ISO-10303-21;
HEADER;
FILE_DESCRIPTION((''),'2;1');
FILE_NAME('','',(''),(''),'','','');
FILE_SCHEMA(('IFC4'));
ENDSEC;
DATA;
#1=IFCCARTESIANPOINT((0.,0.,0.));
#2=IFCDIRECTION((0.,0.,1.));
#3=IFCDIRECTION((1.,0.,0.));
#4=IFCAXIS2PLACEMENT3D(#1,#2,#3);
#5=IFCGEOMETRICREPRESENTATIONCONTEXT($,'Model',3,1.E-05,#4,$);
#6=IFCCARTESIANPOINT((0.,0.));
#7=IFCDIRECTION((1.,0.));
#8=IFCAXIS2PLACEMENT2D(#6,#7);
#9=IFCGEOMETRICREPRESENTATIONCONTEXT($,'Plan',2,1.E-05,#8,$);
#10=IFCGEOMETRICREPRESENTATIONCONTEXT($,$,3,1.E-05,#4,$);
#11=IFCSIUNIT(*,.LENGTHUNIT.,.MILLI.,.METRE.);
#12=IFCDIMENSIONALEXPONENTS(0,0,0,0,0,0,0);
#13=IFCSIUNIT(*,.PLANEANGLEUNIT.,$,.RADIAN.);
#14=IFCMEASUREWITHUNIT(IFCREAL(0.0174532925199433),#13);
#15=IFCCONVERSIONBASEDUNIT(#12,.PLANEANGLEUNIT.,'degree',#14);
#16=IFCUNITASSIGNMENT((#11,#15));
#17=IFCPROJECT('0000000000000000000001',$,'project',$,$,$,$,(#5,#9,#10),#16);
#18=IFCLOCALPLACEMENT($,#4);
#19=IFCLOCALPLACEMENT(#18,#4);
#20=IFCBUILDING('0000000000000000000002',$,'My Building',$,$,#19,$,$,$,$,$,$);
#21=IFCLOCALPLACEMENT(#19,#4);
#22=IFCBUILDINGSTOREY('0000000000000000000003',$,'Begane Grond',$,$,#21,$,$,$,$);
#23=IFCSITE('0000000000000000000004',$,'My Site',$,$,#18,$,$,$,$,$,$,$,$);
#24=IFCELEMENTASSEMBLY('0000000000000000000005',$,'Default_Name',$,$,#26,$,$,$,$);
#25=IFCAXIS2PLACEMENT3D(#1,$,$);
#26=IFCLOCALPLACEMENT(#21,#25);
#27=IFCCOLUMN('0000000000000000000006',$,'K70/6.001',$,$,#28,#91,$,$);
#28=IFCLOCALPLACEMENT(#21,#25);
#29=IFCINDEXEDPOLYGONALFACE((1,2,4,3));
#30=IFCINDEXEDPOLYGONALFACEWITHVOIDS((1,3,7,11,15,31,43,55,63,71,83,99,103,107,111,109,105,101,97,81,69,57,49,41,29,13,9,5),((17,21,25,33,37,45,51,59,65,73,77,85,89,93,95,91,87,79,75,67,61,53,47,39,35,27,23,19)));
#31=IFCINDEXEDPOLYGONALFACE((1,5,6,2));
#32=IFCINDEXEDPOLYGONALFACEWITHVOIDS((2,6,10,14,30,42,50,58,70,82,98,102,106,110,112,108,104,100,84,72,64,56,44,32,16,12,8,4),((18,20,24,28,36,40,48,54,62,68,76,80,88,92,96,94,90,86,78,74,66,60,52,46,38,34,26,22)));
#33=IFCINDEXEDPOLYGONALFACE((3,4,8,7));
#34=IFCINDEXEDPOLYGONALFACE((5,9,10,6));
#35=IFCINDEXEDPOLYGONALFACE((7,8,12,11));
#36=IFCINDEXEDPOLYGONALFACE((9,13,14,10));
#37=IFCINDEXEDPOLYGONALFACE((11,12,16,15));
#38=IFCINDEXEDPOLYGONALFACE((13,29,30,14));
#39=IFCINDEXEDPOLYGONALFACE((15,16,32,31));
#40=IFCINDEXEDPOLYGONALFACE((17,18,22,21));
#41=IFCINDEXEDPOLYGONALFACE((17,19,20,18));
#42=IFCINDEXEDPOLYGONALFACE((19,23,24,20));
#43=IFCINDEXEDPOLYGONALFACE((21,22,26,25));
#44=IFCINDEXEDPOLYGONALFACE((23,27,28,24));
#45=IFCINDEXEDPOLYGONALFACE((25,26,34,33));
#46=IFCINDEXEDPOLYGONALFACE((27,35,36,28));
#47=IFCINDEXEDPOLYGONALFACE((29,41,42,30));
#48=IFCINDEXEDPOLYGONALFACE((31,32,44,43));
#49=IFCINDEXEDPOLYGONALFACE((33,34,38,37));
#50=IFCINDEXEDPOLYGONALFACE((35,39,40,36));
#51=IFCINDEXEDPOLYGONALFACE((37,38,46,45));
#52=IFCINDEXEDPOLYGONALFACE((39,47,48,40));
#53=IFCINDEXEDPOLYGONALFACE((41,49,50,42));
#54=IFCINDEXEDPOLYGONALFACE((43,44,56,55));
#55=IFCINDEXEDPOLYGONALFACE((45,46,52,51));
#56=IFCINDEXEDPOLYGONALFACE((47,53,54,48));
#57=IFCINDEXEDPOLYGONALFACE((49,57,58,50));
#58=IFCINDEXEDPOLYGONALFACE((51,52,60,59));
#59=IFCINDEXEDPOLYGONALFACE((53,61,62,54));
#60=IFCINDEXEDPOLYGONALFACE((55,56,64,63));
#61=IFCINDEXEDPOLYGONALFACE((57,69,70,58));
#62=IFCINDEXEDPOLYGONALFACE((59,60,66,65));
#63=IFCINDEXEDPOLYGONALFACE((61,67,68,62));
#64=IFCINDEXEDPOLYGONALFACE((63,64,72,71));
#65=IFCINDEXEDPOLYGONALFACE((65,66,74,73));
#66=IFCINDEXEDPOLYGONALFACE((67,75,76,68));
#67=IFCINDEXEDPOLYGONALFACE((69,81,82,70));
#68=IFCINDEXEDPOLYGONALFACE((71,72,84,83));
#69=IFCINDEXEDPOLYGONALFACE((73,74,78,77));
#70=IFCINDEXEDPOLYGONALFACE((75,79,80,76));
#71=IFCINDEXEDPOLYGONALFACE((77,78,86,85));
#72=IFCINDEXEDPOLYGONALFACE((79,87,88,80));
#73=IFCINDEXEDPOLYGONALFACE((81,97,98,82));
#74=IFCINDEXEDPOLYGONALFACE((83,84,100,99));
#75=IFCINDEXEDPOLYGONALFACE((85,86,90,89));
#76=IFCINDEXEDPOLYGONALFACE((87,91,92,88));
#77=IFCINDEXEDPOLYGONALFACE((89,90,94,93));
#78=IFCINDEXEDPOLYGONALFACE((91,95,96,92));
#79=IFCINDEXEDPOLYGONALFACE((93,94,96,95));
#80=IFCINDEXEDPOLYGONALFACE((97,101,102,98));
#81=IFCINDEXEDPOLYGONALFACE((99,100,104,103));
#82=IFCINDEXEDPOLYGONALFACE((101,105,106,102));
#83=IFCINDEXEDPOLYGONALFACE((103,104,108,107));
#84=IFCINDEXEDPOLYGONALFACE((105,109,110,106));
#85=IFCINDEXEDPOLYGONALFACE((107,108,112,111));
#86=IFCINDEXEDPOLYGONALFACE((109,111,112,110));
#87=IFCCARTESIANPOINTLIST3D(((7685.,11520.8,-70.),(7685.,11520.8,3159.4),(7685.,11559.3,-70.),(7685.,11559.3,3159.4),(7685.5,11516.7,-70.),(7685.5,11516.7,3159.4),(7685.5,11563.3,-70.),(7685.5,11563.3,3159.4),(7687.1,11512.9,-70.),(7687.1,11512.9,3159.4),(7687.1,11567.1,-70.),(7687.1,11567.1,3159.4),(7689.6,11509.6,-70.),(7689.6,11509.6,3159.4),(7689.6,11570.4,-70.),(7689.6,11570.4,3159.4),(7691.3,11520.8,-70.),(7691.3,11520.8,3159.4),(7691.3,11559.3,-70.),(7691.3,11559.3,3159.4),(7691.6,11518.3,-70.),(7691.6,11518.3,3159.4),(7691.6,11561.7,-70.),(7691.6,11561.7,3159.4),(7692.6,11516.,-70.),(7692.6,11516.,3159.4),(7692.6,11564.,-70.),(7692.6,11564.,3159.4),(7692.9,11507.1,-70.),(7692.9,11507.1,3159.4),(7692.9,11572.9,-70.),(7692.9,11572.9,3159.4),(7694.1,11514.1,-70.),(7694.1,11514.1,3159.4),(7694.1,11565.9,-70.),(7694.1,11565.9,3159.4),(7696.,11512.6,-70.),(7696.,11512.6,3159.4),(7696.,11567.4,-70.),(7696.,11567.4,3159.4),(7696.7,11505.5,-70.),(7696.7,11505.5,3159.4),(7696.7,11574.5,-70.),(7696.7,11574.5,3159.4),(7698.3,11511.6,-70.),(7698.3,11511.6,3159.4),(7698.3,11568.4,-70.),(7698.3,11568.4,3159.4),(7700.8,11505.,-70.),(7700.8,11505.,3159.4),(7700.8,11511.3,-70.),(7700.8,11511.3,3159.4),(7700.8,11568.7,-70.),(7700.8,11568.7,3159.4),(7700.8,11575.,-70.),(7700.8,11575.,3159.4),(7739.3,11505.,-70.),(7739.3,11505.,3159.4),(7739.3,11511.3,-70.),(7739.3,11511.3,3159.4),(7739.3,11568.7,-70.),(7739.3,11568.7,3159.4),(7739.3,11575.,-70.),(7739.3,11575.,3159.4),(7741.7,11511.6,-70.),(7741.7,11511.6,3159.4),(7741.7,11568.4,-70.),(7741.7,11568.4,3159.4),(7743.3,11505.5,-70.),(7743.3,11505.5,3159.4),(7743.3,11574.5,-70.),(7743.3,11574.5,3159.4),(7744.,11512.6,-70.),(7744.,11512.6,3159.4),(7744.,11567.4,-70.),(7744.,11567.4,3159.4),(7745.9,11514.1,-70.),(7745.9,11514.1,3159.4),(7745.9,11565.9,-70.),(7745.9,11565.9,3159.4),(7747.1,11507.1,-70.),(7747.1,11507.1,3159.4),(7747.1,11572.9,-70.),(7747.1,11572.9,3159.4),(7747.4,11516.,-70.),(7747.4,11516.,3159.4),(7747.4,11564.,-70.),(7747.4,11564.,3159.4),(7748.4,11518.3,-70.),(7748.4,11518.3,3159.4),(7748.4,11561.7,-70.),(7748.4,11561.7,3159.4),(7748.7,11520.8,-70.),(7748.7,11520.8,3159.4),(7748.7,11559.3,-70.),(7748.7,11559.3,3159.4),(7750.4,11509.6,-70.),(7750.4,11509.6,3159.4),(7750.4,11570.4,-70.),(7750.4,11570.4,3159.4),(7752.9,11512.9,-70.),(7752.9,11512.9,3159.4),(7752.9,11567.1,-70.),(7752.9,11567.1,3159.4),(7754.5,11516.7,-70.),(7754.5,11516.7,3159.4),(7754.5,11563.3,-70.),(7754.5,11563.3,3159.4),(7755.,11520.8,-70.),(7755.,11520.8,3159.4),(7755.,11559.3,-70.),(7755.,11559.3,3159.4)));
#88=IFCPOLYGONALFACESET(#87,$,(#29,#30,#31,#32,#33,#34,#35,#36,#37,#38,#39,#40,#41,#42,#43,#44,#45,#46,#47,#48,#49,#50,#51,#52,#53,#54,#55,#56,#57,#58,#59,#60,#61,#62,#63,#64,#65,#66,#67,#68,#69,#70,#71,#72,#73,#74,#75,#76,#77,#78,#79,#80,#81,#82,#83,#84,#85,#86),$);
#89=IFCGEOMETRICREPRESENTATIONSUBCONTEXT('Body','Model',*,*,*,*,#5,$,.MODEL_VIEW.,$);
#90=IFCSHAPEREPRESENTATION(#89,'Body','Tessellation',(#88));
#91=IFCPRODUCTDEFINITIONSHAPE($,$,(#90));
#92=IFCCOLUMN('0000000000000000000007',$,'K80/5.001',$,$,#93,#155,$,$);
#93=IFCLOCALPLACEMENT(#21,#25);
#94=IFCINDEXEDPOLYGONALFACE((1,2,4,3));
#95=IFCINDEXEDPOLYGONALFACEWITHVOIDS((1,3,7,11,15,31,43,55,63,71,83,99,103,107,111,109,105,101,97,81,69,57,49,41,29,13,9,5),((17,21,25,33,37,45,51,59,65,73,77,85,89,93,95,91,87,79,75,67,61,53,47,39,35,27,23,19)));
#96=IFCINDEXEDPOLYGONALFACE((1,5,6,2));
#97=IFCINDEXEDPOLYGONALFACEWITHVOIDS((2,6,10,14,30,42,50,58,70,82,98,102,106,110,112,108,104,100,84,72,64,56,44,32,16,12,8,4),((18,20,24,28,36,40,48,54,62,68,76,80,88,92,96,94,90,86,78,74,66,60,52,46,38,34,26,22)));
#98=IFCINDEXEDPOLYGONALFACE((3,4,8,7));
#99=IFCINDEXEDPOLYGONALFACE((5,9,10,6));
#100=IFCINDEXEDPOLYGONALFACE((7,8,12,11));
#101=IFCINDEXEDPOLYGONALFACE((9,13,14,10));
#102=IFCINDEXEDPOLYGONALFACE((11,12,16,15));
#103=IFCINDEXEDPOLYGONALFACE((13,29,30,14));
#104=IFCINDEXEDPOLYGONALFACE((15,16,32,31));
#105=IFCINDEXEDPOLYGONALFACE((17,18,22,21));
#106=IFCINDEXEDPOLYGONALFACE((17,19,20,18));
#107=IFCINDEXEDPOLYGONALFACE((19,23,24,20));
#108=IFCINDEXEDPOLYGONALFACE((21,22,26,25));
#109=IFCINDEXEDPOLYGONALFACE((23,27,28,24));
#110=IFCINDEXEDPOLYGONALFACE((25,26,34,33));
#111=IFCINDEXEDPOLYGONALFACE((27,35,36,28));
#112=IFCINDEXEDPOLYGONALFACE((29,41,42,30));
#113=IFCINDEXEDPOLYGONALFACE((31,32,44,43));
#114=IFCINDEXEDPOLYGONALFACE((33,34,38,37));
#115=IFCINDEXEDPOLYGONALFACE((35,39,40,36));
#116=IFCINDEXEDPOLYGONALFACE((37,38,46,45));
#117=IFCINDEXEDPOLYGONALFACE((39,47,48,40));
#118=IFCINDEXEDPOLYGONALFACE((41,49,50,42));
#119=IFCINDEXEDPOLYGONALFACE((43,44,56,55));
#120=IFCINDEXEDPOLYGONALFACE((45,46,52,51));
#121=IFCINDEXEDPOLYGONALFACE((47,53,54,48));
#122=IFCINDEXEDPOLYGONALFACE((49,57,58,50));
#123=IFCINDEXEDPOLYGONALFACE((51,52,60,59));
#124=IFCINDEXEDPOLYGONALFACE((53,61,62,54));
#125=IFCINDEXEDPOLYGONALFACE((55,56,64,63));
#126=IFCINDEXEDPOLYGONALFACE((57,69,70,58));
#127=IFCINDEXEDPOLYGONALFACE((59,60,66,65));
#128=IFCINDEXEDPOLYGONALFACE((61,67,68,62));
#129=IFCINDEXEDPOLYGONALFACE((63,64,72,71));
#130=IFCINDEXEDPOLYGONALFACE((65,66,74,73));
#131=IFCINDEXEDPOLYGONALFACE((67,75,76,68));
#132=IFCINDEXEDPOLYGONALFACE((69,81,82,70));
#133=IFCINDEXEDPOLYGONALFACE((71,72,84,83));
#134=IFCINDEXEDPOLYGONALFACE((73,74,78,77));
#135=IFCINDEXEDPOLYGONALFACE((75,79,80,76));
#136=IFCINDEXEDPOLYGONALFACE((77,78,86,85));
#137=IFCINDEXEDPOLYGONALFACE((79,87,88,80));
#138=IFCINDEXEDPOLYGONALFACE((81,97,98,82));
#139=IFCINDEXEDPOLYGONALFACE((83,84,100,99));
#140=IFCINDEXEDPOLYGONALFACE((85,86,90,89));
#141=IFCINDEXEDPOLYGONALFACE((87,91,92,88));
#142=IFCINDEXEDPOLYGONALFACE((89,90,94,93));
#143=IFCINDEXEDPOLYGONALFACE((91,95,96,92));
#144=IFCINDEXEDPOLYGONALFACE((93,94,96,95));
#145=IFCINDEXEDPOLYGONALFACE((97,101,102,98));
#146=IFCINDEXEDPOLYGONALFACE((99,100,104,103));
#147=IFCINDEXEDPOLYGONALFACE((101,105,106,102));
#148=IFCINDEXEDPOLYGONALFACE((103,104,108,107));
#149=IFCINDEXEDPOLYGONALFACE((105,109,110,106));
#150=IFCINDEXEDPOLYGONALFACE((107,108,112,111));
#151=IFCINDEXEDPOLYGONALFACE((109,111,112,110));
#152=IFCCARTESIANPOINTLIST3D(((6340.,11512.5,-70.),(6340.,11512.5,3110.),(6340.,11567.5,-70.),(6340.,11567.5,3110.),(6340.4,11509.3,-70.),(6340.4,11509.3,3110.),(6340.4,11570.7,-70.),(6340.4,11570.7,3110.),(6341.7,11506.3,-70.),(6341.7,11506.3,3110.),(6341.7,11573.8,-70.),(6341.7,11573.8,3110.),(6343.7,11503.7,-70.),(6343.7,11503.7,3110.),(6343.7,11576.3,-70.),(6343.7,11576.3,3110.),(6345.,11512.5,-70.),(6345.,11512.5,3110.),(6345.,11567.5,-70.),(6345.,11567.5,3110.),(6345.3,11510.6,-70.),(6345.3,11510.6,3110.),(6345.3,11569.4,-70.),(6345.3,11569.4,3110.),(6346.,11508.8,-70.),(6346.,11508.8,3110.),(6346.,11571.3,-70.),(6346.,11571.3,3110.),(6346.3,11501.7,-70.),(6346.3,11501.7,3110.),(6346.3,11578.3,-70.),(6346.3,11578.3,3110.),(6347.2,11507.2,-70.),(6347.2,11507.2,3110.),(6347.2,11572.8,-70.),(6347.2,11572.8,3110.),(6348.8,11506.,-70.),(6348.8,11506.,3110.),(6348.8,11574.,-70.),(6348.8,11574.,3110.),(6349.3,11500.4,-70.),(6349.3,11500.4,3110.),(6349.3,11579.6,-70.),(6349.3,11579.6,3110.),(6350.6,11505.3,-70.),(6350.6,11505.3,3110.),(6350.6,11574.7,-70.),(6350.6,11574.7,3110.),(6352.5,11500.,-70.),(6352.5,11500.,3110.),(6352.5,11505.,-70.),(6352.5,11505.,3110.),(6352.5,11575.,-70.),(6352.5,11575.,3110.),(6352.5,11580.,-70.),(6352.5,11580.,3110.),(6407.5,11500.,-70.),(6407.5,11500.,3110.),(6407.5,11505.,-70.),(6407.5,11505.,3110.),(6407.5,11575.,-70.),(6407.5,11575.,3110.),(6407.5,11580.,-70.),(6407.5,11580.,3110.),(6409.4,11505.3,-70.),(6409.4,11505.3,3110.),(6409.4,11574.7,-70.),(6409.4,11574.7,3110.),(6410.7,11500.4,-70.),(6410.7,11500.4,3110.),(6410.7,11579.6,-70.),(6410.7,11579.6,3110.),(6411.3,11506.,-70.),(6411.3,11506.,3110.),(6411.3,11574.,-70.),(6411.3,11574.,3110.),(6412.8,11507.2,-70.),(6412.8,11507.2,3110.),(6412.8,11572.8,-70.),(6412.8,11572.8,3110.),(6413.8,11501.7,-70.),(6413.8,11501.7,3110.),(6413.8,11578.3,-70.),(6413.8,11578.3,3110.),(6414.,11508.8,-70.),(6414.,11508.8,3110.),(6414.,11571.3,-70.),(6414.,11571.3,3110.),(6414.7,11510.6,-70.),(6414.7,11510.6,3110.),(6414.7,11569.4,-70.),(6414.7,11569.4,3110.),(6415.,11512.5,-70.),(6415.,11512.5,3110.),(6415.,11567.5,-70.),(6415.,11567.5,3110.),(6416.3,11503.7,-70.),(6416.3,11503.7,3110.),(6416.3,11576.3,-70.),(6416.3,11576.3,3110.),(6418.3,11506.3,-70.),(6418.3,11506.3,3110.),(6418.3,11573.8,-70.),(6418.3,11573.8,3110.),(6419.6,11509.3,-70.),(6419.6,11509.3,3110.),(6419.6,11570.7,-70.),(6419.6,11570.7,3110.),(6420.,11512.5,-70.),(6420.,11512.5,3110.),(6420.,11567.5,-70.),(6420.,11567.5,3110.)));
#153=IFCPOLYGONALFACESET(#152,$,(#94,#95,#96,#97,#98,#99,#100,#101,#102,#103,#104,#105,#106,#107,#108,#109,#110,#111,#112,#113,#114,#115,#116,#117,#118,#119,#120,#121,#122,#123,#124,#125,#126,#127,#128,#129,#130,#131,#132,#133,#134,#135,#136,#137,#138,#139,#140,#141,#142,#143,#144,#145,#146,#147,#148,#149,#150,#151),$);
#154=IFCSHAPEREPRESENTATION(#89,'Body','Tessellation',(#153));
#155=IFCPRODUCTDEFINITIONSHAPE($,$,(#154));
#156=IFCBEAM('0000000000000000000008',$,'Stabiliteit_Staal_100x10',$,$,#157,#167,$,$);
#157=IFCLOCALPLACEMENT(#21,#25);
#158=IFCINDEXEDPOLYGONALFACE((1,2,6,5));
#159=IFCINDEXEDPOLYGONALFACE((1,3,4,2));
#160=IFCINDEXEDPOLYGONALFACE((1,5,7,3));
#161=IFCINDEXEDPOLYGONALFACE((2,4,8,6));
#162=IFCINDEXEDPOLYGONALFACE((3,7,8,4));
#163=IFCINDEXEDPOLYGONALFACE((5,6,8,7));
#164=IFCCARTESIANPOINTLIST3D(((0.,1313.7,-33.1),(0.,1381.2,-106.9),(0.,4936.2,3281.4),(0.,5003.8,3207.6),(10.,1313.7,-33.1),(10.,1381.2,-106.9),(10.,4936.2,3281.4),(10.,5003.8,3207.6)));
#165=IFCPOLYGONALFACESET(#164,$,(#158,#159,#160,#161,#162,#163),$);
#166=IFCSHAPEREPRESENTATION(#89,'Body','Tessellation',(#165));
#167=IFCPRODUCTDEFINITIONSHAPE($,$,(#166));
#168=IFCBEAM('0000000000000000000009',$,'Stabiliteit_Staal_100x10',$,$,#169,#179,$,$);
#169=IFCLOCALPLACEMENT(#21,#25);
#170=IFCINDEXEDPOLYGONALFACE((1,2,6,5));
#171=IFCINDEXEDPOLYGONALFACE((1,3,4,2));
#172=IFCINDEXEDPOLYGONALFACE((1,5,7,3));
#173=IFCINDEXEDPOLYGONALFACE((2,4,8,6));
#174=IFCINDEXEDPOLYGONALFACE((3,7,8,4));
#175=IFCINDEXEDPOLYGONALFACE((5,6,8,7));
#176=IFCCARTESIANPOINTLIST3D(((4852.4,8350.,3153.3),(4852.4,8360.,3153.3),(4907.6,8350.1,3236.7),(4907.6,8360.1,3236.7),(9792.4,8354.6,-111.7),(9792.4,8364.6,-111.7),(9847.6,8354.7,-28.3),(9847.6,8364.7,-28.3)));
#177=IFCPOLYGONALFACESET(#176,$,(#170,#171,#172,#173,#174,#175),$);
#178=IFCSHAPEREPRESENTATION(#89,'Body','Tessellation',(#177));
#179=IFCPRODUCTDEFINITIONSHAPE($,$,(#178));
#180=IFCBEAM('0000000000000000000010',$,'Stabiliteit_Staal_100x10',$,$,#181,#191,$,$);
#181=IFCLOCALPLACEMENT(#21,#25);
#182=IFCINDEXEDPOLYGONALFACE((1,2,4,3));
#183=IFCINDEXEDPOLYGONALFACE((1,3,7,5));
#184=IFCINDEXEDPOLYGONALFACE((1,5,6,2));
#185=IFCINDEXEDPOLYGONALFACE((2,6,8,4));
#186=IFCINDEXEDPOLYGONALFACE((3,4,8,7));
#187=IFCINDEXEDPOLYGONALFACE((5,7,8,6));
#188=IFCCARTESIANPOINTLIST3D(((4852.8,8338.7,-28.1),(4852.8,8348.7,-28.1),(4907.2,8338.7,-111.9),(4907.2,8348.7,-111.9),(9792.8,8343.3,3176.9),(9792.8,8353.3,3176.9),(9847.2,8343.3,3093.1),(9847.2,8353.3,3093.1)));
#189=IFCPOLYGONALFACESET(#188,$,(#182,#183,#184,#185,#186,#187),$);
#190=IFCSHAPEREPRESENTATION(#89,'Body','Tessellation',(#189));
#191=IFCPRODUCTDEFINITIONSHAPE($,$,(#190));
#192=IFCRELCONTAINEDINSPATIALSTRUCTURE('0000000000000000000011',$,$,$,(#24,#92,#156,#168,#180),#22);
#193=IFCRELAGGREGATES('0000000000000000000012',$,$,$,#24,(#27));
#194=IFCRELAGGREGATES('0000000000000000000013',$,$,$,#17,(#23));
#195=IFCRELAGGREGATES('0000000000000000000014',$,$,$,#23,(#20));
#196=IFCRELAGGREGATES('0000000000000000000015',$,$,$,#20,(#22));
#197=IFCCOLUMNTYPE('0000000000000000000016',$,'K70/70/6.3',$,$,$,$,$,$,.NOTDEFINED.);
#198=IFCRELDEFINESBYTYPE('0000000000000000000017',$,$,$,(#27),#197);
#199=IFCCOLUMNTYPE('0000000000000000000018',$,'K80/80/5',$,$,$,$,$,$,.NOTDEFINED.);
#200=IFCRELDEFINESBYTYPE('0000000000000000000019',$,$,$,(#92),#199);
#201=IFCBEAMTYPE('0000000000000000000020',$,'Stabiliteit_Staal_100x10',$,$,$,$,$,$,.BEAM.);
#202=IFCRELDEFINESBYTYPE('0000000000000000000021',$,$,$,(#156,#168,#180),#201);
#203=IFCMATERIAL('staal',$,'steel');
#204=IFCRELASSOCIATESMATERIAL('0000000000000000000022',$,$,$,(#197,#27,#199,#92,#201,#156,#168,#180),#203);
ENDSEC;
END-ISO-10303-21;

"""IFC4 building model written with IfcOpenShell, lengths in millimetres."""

from ifc_helpers import new_model, entity, si_unit, converted_unit, frame, origin_with_axes, origin_2d_with_axis, place, context, subcontext, project, spatial, rectangle, hollow_rectangle, extrude, material, material_profile, profile_set, profile_usage, type_object, element, aggregate, save


model = new_model("IFC4")

# Units and contexts
model_context = context("Model", 3, precision=1e-05, world=origin_with_axes())
plan_context = context("Plan", 2, precision=1e-05, world=origin_2d_with_axis())
context_of_model = context(None, 3, precision=1e-05, world=origin_with_axes())
body_context = subcontext(model_context, "Body", "Model", "MODEL_VIEW")
ifc_project = project(units=[si_unit("LENGTHUNIT", "METRE", prefix="MILLI"), converted_unit("PLANEANGLEUNIT", "degree", entity("IfcReal", 0.0174532925199433), si_unit("PLANEANGLEUNIT", "RADIAN"), dimensions=[0, 0, 0, 0, 0, 0, 0])], contexts=[model_context, plan_context, context_of_model])

# Site, building, storey
site_placement = place(None, origin_with_axes())
site = spatial("IfcSite", under=ifc_project, at=site_placement, Name="My Site")
building_placement = place(site_placement, origin_with_axes())
building = spatial("IfcBuilding", under=site, at=building_placement, Name="My Building")
storey_placement = place(building_placement, origin_with_axes())
storey = spatial("IfcBuildingStorey", under=building, at=storey_placement, Name="Begane Grond")

# Shared definitions
ifc_material = material(Name="staal", Category="steel")

# Element assembly, column
assembly_placement = place(storey_placement, origin_with_axes())
assembly = element("IfcElementAssembly", 1, at=assembly_placement, inside=storey, Name="Default_Name")
ifc_material_profile_1 = material_profile(ifc_material, hollow_rectangle(XDim=70.0, YDim=70.0, WallThickness=6.3, InnerFilletRadius=9.4, OuterFilletRadius=15.8))
ifc_profile_set_1 = profile_set([ifc_material_profile_1], Name="K70/70/6.3")
ifc_profile_usage_1 = profile_usage(ifc_profile_set_1)
column_type_1 = type_object("IfcColumnType", Name="K70/70/6.3", PredefinedType="NOTDEFINED", material=ifc_profile_set_1)
column_1_placement = place(assembly_placement, frame((7720.0, 11540.0, -70.0), z_axis=(0.0, 0.0, 1.0), x_axis=(1.0, 0.0, 0.0)))
column_1 = element("IfcColumn", 2, at=column_1_placement, type_object=column_type_1, material=ifc_profile_usage_1, Name="K70/6.001", context=body_context, shape_type="SweptSolid", body=[
    extrude(hollow_rectangle(XDim=70.0, YDim=70.0, WallThickness=6.3, InnerFilletRadius=9.4, OuterFilletRadius=15.8), origin_with_axes(), (0.0, 0.0, 1.0), 3229.4),
])
aggregate(assembly, [column_1])

# Column
ifc_material_profile_2 = material_profile(ifc_material, hollow_rectangle(XDim=80.0, YDim=80.0, WallThickness=5.0, InnerFilletRadius=7.5, OuterFilletRadius=12.5))
ifc_profile_set_2 = profile_set([ifc_material_profile_2], Name="K80/80/5")
ifc_profile_usage_2 = profile_usage(ifc_profile_set_2)
column_type_2 = type_object("IfcColumnType", Name="K80/80/5", PredefinedType="NOTDEFINED", material=ifc_profile_set_2)
column_2_placement = place(storey_placement, frame((6380.0, 11540.0, -70.0), z_axis=(0.0, 0.0, 1.0), x_axis=(1.0, 0.0, 0.0)))
element("IfcColumn", 3, at=column_2_placement, inside=storey, type_object=column_type_2, material=ifc_profile_usage_2, Name="K80/5.001", context=body_context, shape_type="SweptSolid", body=[
    extrude(hollow_rectangle(XDim=80.0, YDim=80.0, WallThickness=5.0, InnerFilletRadius=7.5, OuterFilletRadius=12.5), origin_with_axes(), (0.0, 0.0, 1.0), 3180.0),
])

# Beams
ifc_material_profile_3 = material_profile(ifc_material, rectangle(XDim=10.0, YDim=100.0, kind="CURVE"))
ifc_profile_set_3 = profile_set([ifc_material_profile_3])
ifc_profile_usage_3 = profile_usage(ifc_profile_set_3, cardinal=5)
beam_type = type_object("IfcBeamType", Name="Stabiliteit_Staal_100x10", PredefinedType="BEAM", material=ifc_profile_set_3)
beam_1_placement = place(storey_placement, frame((5.0, 1347.5, -70.0), z_axis=(0.0, 0.737776, 0.675046), x_axis=(-1.0, 0.0, 0.0)))
element("IfcBeam", 4, at=beam_1_placement, inside=storey, type_object=beam_type, material=ifc_profile_usage_3, Name="Stabiliteit_Staal_100x10", context=body_context, shape_type="SweptSolid", body=[
    extrude(rectangle(XDim=10.0, YDim=100.0, kind="CURVE"), origin_with_axes(), (0.0, 0.0, 1.0), 4910.0),
])
ifc_profile_usage_4 = profile_usage(ifc_profile_set_3, cardinal=5)
beam_2_placement = place(storey_placement, frame((9820.0, 8359.7, -70.0), z_axis=(-0.834252, -0.000783, 0.551383), x_axis=(0.000938, -1.0, 0.0)))
element("IfcBeam", 5, at=beam_2_placement, inside=storey, type_object=beam_type, material=ifc_profile_usage_4, Name="Stabiliteit_Staal_100x10", context=body_context, shape_type="SweptSolid", body=[
    extrude(rectangle(XDim=10.0, YDim=100.0, kind="CURVE"), origin_with_axes(), (0.0, 0.0, 1.0), 5921.5),
])
ifc_profile_usage_5 = profile_usage(ifc_profile_set_3, cardinal=5)
beam_3_placement = place(storey_placement, frame((4880.0, 8343.7, -70.0), z_axis=(0.838909, 0.000787, 0.544272), x_axis=(-0.000938, 1.0, 0.0)))
element("IfcBeam", 6, at=beam_3_placement, inside=storey, type_object=beam_type, material=ifc_profile_usage_5, Name="Stabiliteit_Staal_100x10", context=body_context, shape_type="SweptSolid", body=[
    extrude(rectangle(XDim=10.0, YDim=100.0, kind="CURVE"), origin_with_axes(), (0.0, 0.0, 1.0), 5888.6),
])

save(model, "model.ifc")
